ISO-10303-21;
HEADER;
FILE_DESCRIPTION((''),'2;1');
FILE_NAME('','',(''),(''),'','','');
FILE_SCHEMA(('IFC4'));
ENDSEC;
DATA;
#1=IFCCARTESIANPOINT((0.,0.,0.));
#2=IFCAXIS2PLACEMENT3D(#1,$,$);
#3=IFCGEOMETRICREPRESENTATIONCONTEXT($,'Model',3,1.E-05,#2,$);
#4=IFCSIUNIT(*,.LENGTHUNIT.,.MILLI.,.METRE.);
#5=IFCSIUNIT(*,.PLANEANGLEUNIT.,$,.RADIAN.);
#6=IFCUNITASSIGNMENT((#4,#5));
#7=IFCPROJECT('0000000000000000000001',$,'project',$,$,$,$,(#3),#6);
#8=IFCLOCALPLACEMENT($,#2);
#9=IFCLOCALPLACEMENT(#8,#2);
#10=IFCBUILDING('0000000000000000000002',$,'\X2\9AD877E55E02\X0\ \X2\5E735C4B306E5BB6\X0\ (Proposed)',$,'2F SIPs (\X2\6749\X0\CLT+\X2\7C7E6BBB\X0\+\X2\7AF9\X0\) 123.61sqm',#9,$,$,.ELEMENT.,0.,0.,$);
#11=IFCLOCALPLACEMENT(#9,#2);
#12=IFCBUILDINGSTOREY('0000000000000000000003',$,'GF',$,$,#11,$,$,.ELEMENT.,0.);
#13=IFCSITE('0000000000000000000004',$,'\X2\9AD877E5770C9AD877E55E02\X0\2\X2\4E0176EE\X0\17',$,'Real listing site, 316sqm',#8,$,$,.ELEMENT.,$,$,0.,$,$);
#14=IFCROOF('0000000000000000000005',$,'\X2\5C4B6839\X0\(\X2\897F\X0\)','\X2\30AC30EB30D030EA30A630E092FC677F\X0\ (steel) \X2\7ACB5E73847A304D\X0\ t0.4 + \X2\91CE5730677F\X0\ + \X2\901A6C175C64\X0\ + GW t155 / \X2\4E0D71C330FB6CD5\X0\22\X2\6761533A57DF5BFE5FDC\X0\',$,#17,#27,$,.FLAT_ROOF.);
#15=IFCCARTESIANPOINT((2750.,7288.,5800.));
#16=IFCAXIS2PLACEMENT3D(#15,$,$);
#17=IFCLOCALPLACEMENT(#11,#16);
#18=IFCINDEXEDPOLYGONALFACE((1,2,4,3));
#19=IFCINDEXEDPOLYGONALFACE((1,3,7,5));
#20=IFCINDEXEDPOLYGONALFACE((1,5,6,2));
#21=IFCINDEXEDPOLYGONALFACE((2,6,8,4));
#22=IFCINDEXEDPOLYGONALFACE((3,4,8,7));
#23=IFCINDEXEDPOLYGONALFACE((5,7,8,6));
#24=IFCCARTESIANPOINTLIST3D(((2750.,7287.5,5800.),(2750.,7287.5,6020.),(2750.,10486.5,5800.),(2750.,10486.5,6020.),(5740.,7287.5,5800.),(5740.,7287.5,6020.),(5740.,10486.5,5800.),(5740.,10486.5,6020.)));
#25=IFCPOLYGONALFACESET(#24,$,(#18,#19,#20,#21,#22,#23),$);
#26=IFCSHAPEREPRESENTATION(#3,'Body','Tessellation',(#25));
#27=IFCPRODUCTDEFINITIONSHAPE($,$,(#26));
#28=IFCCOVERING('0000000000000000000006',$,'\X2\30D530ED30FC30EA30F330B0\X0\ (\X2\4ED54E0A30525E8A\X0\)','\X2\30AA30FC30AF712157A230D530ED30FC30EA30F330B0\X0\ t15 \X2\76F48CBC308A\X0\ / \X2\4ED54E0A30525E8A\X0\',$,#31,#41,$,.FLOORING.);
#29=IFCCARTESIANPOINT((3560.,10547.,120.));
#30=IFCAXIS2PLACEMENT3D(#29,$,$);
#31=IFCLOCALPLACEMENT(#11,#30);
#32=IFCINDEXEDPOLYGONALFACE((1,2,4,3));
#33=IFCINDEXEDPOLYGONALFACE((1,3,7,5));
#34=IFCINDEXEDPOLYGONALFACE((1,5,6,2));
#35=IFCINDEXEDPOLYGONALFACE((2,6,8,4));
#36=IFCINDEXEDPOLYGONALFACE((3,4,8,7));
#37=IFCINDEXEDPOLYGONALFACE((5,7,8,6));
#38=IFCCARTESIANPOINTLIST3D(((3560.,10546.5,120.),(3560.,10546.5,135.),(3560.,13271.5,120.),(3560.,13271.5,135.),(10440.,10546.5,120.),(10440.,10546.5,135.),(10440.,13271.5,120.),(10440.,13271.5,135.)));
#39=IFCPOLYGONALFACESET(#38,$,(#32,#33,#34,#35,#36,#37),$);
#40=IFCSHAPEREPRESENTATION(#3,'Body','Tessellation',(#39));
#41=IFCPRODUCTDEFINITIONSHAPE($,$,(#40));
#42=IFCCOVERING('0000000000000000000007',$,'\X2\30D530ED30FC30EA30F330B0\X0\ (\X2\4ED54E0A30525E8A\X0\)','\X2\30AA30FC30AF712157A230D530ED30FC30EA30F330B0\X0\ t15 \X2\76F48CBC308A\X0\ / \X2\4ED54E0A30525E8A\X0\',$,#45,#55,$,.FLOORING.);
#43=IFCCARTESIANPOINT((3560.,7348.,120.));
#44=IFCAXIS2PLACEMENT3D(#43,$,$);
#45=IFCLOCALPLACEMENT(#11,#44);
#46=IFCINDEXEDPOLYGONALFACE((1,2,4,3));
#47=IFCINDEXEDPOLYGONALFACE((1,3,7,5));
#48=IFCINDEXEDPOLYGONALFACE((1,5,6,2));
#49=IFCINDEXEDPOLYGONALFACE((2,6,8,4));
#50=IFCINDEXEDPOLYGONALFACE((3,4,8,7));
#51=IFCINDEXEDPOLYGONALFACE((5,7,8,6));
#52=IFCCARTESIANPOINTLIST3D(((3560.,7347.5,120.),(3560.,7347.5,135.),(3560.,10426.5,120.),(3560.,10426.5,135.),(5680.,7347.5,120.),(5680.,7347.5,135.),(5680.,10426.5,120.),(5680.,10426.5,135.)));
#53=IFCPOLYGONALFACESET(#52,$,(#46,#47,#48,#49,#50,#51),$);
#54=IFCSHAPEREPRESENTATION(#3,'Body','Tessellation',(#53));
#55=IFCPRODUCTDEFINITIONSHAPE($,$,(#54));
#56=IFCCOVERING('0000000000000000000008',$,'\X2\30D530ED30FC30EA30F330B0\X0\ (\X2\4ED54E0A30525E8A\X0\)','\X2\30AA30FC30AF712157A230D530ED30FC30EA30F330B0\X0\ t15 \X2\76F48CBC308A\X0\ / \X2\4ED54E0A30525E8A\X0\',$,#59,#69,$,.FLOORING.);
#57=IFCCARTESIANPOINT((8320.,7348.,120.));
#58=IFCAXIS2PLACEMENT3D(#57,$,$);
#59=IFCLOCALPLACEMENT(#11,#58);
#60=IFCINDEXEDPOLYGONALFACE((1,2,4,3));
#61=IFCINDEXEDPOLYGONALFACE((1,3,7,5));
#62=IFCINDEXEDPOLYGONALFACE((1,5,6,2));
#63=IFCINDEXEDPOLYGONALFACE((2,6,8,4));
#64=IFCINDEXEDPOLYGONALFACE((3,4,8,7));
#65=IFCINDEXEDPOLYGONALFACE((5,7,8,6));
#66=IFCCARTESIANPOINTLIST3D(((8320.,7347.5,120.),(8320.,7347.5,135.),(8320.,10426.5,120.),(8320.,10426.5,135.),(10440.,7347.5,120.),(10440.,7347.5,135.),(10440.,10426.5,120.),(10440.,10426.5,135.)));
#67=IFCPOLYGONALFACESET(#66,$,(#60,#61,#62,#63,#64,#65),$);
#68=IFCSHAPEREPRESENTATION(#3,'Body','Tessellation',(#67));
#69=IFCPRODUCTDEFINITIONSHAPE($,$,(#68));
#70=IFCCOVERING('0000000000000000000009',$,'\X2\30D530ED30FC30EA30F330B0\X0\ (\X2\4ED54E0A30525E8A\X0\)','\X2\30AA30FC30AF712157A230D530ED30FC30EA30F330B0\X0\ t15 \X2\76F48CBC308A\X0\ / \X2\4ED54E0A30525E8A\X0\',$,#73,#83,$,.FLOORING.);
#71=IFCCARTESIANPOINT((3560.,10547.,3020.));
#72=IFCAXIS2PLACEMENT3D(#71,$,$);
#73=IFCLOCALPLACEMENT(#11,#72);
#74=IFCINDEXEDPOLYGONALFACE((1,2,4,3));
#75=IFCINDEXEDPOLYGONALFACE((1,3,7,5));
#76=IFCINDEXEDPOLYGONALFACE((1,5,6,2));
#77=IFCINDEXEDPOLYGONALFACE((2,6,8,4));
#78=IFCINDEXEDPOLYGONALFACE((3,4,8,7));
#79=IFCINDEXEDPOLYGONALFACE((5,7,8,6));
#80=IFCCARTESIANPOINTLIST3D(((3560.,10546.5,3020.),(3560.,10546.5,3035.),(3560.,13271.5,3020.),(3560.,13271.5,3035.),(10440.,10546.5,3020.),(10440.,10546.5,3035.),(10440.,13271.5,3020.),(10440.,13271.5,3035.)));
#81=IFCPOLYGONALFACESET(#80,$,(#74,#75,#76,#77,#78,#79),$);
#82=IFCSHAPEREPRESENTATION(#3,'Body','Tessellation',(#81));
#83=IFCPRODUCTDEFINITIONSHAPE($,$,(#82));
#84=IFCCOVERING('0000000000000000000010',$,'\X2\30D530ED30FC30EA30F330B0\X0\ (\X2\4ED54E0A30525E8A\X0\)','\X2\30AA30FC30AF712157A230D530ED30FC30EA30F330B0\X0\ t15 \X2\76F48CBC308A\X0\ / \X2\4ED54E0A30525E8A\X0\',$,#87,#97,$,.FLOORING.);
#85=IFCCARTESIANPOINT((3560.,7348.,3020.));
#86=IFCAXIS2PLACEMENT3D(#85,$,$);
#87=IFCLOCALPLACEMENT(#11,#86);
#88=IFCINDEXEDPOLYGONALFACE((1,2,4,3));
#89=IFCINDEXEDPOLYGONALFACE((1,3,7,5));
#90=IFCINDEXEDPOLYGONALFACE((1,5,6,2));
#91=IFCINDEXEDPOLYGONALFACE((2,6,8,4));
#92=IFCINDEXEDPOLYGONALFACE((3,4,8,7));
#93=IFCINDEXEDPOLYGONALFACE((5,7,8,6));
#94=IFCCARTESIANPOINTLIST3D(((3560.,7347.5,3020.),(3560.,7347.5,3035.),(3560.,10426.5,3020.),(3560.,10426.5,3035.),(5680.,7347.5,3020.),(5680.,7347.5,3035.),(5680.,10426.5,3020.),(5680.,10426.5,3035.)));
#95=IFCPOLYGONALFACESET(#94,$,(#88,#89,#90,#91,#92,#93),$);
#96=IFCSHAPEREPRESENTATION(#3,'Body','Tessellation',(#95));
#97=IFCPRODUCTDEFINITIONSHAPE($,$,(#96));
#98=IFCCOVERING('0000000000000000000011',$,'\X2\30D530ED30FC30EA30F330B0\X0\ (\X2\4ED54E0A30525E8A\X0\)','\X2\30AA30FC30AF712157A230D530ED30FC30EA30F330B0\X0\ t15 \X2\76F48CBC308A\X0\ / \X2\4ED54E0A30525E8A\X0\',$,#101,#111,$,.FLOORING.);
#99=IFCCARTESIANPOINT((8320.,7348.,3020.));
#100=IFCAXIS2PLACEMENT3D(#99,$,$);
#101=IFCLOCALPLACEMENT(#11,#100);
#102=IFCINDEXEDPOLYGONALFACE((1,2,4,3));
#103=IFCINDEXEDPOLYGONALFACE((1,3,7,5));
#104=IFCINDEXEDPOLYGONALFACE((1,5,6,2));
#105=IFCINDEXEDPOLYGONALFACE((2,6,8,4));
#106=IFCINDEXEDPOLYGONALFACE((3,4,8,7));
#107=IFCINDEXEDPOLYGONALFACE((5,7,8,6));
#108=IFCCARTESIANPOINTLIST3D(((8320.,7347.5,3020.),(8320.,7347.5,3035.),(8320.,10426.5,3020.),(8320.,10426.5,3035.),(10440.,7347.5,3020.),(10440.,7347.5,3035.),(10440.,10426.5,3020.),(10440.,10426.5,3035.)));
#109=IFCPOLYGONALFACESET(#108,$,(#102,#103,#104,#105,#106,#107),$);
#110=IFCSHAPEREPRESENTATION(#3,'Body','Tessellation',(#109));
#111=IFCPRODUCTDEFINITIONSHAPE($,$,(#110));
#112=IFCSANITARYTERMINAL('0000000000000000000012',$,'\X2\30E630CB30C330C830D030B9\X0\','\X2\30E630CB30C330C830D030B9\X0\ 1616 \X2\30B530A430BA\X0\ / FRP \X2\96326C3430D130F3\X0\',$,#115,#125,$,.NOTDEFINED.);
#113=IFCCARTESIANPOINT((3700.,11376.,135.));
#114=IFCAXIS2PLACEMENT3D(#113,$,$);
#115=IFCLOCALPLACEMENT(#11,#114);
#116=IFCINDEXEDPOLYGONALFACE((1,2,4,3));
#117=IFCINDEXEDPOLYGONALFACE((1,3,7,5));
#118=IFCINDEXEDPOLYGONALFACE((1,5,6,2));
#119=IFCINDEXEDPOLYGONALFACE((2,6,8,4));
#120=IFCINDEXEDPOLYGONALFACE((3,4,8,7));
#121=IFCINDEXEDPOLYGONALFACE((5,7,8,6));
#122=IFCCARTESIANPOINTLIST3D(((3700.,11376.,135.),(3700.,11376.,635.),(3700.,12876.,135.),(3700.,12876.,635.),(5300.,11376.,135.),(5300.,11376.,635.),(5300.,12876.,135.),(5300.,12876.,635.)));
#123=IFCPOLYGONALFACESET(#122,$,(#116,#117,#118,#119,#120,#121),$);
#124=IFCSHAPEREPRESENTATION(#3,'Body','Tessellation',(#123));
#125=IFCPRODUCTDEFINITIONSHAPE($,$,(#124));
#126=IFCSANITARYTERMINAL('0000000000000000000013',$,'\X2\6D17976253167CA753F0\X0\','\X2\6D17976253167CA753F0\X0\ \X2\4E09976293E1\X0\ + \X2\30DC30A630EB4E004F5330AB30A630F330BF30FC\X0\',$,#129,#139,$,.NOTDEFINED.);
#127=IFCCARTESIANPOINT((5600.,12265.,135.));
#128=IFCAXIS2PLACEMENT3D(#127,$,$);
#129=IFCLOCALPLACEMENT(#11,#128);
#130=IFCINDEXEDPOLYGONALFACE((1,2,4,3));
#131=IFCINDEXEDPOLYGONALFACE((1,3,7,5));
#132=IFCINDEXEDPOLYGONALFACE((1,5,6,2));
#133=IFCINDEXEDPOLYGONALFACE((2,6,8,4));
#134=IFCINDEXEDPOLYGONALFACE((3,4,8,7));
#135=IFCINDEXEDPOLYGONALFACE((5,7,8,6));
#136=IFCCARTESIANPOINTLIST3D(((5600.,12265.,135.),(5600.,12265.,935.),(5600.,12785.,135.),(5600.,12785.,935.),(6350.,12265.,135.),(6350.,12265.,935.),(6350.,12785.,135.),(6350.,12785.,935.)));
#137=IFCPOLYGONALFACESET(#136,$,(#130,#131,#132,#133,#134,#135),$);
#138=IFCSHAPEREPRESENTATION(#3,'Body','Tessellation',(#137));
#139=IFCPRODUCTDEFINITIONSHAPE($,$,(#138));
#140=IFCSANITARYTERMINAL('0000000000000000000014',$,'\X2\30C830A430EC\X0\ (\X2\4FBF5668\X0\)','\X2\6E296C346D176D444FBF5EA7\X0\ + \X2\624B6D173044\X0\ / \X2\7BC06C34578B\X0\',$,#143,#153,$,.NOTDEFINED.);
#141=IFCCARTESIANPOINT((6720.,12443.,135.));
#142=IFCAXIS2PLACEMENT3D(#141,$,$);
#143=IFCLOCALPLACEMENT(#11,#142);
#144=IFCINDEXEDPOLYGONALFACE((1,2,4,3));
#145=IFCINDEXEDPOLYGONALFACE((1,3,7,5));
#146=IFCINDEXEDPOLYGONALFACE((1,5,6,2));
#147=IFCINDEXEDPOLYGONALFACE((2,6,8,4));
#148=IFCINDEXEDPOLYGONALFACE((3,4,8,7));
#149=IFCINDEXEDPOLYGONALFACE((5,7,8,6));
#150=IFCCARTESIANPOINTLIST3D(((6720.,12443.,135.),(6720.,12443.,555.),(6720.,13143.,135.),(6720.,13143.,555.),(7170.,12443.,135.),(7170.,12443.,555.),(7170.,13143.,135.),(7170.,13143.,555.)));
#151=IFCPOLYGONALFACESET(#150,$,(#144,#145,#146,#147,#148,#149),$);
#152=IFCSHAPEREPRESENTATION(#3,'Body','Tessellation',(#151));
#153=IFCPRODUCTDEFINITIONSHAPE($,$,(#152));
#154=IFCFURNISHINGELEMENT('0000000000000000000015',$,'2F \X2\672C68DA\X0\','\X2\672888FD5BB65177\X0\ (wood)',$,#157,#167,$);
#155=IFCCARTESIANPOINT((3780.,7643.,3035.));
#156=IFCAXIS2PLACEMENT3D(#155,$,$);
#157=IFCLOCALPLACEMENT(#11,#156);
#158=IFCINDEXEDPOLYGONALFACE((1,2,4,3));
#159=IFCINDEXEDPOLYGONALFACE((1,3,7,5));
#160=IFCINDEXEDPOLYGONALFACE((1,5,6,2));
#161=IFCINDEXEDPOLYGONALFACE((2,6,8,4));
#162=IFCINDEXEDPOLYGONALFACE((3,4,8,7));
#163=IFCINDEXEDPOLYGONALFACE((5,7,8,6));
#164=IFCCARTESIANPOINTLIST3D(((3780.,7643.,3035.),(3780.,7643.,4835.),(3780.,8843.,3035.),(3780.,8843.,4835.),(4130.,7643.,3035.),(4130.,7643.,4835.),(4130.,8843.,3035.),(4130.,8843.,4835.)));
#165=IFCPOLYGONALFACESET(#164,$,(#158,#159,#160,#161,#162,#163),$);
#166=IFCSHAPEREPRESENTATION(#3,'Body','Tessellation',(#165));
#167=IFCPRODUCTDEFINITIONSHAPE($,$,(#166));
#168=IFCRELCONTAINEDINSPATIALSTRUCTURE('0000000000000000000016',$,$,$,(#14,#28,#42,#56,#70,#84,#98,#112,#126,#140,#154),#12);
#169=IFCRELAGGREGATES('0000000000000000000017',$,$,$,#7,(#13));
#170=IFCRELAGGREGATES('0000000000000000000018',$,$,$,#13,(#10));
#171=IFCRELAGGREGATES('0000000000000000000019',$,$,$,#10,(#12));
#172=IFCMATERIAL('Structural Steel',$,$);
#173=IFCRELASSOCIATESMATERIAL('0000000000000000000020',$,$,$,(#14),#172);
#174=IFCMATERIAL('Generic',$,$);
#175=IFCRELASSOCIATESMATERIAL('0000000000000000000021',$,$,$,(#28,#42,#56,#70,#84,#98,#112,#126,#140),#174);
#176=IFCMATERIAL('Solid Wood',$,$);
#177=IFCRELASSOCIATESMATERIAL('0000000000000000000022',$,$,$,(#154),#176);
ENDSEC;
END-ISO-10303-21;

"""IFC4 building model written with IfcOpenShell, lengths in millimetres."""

from ifc_helpers import new_model, si_unit, frame, frame_2d, origin, place, context, project, spatial, rectangle, extrude, material, element, save


model = new_model("IFC4")

# Units and contexts
model_context = context("Model", 3, precision=1e-05, world=origin())
ifc_project = project(units=[si_unit("LENGTHUNIT", "METRE", prefix="MILLI"), si_unit("PLANEANGLEUNIT", "RADIAN")], contexts=[model_context])

# Site, building, storey
site_placement = place(None, origin())
site = spatial("IfcSite", under=ifc_project, at=site_placement, Name="高知県高知市2丁目17", ObjectType="Real listing site, 316sqm", CompositionType="ELEMENT", RefElevation=0.0)
building_placement = place(site_placement, origin())
building = spatial("IfcBuilding", under=site, at=building_placement, Name="高知市 平屋の家 (Proposed)", ObjectType="2F SIPs (杉CLT+籾殻+竹) 123.61sqm", CompositionType="ELEMENT", ElevationOfRefHeight=0.0, ElevationOfTerrain=0.0)
storey_placement = place(building_placement, origin())
storey = spatial("IfcBuildingStorey", under=building, at=storey_placement, Name="GF", CompositionType="ELEMENT", Elevation=0.0)

# Shared definitions
ifc_material_1 = material(Name="Solid Wood")

# Shared definitions
ifc_material_2 = material(Name="Generic")

# Roof
ifc_material_3 = material(Name="Structural Steel")
roof_1_placement = place(storey_placement, frame((2750.0, 7288.0, 5800.0)))
element("IfcRoof", 1, at=roof_1_placement, inside=storey, material=ifc_material_3, Name="屋根(西)", Description="ガルバリウム鋼板 (steel) 立平葺き t0.4 + 野地板 + 通気層 + GW t155 / 不燃・法22条区域対応", PredefinedType="FLAT_ROOF", context=model_context, shape_type="SweptSolid", body=[
    extrude(rectangle(XDim=2990.0, YDim=3199.0, at=frame_2d((1495.0, 1599.0))), frame((2750.0, 7288.0, 5800.0)), (0.0, 0.0, 1.0), 220.0),
])

# Coverings
covering_1_placement = place(storey_placement, frame((3560.0, 10547.0, 120.0)))
element("IfcCovering", 2, at=covering_1_placement, inside=storey, material=ifc_material_2, Name="フローリング (仕上げ床)", Description="オーク無垢フローリング t15 直貼り / 仕上げ床", PredefinedType="FLOORING", context=model_context, shape_type="SweptSolid", body=[
    extrude(rectangle(XDim=6880.0, YDim=2725.0, at=frame_2d((3440.0, 1362.0))), frame((3560.0, 10547.0, 120.0)), (0.0, 0.0, 1.0), 15.0),
])
covering_2_placement = place(storey_placement, frame((3560.0, 7348.0, 120.0)))
element("IfcCovering", 3, at=covering_2_placement, inside=storey, material=ifc_material_2, Name="フローリング (仕上げ床)", Description="オーク無垢フローリング t15 直貼り / 仕上げ床", PredefinedType="FLOORING", context=model_context, shape_type="SweptSolid", body=[
    extrude(rectangle(XDim=2120.0, YDim=3079.0, at=frame_2d((1060.0, 1539.0))), frame((3560.0, 7348.0, 120.0)), (0.0, 0.0, 1.0), 15.0),
])
covering_3_placement = place(storey_placement, frame((8320.0, 7348.0, 120.0)))
element("IfcCovering", 4, at=covering_3_placement, inside=storey, material=ifc_material_2, Name="フローリング (仕上げ床)", Description="オーク無垢フローリング t15 直貼り / 仕上げ床", PredefinedType="FLOORING", context=model_context, shape_type="SweptSolid", body=[
    extrude(rectangle(XDim=2120.0, YDim=3079.0, at=frame_2d((1060.0, 1539.0))), frame((8320.0, 7348.0, 120.0)), (0.0, 0.0, 1.0), 15.0),
])
covering_4_placement = place(storey_placement, frame((3560.0, 10547.0, 3020.0)))
element("IfcCovering", 5, at=covering_4_placement, inside=storey, material=ifc_material_2, Name="フローリング (仕上げ床)", Description="オーク無垢フローリング t15 直貼り / 仕上げ床", PredefinedType="FLOORING", context=model_context, shape_type="SweptSolid", body=[
    extrude(rectangle(XDim=6880.0, YDim=2725.0, at=frame_2d((3440.0, 1362.0))), frame((3560.0, 10547.0, 3020.0)), (0.0, 0.0, 1.0), 15.0),
])
covering_5_placement = place(storey_placement, frame((3560.0, 7348.0, 3020.0)))
element("IfcCovering", 6, at=covering_5_placement, inside=storey, material=ifc_material_2, Name="フローリング (仕上げ床)", Description="オーク無垢フローリング t15 直貼り / 仕上げ床", PredefinedType="FLOORING", context=model_context, shape_type="SweptSolid", body=[
    extrude(rectangle(XDim=2120.0, YDim=3079.0, at=frame_2d((1060.0, 1539.0))), frame((3560.0, 7348.0, 3020.0)), (0.0, 0.0, 1.0), 15.0),
])
covering_6_placement = place(storey_placement, frame((8320.0, 7348.0, 3020.0)))
element("IfcCovering", 7, at=covering_6_placement, inside=storey, material=ifc_material_2, Name="フローリング (仕上げ床)", Description="オーク無垢フローリング t15 直貼り / 仕上げ床", PredefinedType="FLOORING", context=model_context, shape_type="SweptSolid", body=[
    extrude(rectangle(XDim=2120.0, YDim=3079.0, at=frame_2d((1060.0, 1539.0))), frame((8320.0, 7348.0, 3020.0)), (0.0, 0.0, 1.0), 15.0),
])

# Sanitary terminals
sanitary_terminal_1_placement = place(storey_placement, frame((3700.0, 11376.0, 135.0)))
element("IfcSanitaryTerminal", 8, at=sanitary_terminal_1_placement, inside=storey, material=ifc_material_2, Name="ユニットバス", Description="ユニットバス 1616 サイズ / FRP 防水パン", PredefinedType="NOTDEFINED", context=model_context, shape_type="SweptSolid", body=[
    extrude(rectangle(XDim=1600.0, YDim=1500.0, at=frame_2d((800.0, 750.0))), frame((3700.0, 11376.0, 135.0)), (0.0, 0.0, 1.0), 500.0),
])
sanitary_terminal_2_placement = place(storey_placement, frame((5600.0, 12265.0, 135.0)))
element("IfcSanitaryTerminal", 9, at=sanitary_terminal_2_placement, inside=storey, material=ifc_material_2, Name="洗面化粧台", Description="洗面化粧台 三面鏡 + ボウル一体カウンター", PredefinedType="NOTDEFINED", context=model_context, shape_type="SweptSolid", body=[
    extrude(rectangle(XDim=750.0, YDim=520.0, at=frame_2d((375.0, 260.0))), frame((5600.0, 12265.0, 135.0)), (0.0, 0.0, 1.0), 800.0),
])
sanitary_terminal_3_placement = place(storey_placement, frame((6720.0, 12443.0, 135.0)))
element("IfcSanitaryTerminal", 10, at=sanitary_terminal_3_placement, inside=storey, material=ifc_material_2, Name="トイレ (便器)", Description="温水洗浄便座 + 手洗い / 節水型", PredefinedType="NOTDEFINED", context=model_context, shape_type="SweptSolid", body=[
    extrude(rectangle(XDim=450.0, YDim=700.0, at=frame_2d((225.0, 350.0))), frame((6720.0, 12443.0, 135.0)), (0.0, 0.0, 1.0), 420.0),
])

# Furnishing element
furnishing_placement = place(storey_placement, frame((3780.0, 7643.0, 3035.0)))
element("IfcFurnishingElement", 11, at=furnishing_placement, inside=storey, material=ifc_material_1, Name="2F 本棚", Description="木製家具 (wood)", context=model_context, shape_type="SweptSolid", body=[
    extrude(rectangle(XDim=350.0, YDim=1200.0, at=frame_2d((175.0, 600.0))), frame((3780.0, 7643.0, 3035.0)), (0.0, 0.0, 1.0), 1800.0),
])

save(model, "model.ifc")
